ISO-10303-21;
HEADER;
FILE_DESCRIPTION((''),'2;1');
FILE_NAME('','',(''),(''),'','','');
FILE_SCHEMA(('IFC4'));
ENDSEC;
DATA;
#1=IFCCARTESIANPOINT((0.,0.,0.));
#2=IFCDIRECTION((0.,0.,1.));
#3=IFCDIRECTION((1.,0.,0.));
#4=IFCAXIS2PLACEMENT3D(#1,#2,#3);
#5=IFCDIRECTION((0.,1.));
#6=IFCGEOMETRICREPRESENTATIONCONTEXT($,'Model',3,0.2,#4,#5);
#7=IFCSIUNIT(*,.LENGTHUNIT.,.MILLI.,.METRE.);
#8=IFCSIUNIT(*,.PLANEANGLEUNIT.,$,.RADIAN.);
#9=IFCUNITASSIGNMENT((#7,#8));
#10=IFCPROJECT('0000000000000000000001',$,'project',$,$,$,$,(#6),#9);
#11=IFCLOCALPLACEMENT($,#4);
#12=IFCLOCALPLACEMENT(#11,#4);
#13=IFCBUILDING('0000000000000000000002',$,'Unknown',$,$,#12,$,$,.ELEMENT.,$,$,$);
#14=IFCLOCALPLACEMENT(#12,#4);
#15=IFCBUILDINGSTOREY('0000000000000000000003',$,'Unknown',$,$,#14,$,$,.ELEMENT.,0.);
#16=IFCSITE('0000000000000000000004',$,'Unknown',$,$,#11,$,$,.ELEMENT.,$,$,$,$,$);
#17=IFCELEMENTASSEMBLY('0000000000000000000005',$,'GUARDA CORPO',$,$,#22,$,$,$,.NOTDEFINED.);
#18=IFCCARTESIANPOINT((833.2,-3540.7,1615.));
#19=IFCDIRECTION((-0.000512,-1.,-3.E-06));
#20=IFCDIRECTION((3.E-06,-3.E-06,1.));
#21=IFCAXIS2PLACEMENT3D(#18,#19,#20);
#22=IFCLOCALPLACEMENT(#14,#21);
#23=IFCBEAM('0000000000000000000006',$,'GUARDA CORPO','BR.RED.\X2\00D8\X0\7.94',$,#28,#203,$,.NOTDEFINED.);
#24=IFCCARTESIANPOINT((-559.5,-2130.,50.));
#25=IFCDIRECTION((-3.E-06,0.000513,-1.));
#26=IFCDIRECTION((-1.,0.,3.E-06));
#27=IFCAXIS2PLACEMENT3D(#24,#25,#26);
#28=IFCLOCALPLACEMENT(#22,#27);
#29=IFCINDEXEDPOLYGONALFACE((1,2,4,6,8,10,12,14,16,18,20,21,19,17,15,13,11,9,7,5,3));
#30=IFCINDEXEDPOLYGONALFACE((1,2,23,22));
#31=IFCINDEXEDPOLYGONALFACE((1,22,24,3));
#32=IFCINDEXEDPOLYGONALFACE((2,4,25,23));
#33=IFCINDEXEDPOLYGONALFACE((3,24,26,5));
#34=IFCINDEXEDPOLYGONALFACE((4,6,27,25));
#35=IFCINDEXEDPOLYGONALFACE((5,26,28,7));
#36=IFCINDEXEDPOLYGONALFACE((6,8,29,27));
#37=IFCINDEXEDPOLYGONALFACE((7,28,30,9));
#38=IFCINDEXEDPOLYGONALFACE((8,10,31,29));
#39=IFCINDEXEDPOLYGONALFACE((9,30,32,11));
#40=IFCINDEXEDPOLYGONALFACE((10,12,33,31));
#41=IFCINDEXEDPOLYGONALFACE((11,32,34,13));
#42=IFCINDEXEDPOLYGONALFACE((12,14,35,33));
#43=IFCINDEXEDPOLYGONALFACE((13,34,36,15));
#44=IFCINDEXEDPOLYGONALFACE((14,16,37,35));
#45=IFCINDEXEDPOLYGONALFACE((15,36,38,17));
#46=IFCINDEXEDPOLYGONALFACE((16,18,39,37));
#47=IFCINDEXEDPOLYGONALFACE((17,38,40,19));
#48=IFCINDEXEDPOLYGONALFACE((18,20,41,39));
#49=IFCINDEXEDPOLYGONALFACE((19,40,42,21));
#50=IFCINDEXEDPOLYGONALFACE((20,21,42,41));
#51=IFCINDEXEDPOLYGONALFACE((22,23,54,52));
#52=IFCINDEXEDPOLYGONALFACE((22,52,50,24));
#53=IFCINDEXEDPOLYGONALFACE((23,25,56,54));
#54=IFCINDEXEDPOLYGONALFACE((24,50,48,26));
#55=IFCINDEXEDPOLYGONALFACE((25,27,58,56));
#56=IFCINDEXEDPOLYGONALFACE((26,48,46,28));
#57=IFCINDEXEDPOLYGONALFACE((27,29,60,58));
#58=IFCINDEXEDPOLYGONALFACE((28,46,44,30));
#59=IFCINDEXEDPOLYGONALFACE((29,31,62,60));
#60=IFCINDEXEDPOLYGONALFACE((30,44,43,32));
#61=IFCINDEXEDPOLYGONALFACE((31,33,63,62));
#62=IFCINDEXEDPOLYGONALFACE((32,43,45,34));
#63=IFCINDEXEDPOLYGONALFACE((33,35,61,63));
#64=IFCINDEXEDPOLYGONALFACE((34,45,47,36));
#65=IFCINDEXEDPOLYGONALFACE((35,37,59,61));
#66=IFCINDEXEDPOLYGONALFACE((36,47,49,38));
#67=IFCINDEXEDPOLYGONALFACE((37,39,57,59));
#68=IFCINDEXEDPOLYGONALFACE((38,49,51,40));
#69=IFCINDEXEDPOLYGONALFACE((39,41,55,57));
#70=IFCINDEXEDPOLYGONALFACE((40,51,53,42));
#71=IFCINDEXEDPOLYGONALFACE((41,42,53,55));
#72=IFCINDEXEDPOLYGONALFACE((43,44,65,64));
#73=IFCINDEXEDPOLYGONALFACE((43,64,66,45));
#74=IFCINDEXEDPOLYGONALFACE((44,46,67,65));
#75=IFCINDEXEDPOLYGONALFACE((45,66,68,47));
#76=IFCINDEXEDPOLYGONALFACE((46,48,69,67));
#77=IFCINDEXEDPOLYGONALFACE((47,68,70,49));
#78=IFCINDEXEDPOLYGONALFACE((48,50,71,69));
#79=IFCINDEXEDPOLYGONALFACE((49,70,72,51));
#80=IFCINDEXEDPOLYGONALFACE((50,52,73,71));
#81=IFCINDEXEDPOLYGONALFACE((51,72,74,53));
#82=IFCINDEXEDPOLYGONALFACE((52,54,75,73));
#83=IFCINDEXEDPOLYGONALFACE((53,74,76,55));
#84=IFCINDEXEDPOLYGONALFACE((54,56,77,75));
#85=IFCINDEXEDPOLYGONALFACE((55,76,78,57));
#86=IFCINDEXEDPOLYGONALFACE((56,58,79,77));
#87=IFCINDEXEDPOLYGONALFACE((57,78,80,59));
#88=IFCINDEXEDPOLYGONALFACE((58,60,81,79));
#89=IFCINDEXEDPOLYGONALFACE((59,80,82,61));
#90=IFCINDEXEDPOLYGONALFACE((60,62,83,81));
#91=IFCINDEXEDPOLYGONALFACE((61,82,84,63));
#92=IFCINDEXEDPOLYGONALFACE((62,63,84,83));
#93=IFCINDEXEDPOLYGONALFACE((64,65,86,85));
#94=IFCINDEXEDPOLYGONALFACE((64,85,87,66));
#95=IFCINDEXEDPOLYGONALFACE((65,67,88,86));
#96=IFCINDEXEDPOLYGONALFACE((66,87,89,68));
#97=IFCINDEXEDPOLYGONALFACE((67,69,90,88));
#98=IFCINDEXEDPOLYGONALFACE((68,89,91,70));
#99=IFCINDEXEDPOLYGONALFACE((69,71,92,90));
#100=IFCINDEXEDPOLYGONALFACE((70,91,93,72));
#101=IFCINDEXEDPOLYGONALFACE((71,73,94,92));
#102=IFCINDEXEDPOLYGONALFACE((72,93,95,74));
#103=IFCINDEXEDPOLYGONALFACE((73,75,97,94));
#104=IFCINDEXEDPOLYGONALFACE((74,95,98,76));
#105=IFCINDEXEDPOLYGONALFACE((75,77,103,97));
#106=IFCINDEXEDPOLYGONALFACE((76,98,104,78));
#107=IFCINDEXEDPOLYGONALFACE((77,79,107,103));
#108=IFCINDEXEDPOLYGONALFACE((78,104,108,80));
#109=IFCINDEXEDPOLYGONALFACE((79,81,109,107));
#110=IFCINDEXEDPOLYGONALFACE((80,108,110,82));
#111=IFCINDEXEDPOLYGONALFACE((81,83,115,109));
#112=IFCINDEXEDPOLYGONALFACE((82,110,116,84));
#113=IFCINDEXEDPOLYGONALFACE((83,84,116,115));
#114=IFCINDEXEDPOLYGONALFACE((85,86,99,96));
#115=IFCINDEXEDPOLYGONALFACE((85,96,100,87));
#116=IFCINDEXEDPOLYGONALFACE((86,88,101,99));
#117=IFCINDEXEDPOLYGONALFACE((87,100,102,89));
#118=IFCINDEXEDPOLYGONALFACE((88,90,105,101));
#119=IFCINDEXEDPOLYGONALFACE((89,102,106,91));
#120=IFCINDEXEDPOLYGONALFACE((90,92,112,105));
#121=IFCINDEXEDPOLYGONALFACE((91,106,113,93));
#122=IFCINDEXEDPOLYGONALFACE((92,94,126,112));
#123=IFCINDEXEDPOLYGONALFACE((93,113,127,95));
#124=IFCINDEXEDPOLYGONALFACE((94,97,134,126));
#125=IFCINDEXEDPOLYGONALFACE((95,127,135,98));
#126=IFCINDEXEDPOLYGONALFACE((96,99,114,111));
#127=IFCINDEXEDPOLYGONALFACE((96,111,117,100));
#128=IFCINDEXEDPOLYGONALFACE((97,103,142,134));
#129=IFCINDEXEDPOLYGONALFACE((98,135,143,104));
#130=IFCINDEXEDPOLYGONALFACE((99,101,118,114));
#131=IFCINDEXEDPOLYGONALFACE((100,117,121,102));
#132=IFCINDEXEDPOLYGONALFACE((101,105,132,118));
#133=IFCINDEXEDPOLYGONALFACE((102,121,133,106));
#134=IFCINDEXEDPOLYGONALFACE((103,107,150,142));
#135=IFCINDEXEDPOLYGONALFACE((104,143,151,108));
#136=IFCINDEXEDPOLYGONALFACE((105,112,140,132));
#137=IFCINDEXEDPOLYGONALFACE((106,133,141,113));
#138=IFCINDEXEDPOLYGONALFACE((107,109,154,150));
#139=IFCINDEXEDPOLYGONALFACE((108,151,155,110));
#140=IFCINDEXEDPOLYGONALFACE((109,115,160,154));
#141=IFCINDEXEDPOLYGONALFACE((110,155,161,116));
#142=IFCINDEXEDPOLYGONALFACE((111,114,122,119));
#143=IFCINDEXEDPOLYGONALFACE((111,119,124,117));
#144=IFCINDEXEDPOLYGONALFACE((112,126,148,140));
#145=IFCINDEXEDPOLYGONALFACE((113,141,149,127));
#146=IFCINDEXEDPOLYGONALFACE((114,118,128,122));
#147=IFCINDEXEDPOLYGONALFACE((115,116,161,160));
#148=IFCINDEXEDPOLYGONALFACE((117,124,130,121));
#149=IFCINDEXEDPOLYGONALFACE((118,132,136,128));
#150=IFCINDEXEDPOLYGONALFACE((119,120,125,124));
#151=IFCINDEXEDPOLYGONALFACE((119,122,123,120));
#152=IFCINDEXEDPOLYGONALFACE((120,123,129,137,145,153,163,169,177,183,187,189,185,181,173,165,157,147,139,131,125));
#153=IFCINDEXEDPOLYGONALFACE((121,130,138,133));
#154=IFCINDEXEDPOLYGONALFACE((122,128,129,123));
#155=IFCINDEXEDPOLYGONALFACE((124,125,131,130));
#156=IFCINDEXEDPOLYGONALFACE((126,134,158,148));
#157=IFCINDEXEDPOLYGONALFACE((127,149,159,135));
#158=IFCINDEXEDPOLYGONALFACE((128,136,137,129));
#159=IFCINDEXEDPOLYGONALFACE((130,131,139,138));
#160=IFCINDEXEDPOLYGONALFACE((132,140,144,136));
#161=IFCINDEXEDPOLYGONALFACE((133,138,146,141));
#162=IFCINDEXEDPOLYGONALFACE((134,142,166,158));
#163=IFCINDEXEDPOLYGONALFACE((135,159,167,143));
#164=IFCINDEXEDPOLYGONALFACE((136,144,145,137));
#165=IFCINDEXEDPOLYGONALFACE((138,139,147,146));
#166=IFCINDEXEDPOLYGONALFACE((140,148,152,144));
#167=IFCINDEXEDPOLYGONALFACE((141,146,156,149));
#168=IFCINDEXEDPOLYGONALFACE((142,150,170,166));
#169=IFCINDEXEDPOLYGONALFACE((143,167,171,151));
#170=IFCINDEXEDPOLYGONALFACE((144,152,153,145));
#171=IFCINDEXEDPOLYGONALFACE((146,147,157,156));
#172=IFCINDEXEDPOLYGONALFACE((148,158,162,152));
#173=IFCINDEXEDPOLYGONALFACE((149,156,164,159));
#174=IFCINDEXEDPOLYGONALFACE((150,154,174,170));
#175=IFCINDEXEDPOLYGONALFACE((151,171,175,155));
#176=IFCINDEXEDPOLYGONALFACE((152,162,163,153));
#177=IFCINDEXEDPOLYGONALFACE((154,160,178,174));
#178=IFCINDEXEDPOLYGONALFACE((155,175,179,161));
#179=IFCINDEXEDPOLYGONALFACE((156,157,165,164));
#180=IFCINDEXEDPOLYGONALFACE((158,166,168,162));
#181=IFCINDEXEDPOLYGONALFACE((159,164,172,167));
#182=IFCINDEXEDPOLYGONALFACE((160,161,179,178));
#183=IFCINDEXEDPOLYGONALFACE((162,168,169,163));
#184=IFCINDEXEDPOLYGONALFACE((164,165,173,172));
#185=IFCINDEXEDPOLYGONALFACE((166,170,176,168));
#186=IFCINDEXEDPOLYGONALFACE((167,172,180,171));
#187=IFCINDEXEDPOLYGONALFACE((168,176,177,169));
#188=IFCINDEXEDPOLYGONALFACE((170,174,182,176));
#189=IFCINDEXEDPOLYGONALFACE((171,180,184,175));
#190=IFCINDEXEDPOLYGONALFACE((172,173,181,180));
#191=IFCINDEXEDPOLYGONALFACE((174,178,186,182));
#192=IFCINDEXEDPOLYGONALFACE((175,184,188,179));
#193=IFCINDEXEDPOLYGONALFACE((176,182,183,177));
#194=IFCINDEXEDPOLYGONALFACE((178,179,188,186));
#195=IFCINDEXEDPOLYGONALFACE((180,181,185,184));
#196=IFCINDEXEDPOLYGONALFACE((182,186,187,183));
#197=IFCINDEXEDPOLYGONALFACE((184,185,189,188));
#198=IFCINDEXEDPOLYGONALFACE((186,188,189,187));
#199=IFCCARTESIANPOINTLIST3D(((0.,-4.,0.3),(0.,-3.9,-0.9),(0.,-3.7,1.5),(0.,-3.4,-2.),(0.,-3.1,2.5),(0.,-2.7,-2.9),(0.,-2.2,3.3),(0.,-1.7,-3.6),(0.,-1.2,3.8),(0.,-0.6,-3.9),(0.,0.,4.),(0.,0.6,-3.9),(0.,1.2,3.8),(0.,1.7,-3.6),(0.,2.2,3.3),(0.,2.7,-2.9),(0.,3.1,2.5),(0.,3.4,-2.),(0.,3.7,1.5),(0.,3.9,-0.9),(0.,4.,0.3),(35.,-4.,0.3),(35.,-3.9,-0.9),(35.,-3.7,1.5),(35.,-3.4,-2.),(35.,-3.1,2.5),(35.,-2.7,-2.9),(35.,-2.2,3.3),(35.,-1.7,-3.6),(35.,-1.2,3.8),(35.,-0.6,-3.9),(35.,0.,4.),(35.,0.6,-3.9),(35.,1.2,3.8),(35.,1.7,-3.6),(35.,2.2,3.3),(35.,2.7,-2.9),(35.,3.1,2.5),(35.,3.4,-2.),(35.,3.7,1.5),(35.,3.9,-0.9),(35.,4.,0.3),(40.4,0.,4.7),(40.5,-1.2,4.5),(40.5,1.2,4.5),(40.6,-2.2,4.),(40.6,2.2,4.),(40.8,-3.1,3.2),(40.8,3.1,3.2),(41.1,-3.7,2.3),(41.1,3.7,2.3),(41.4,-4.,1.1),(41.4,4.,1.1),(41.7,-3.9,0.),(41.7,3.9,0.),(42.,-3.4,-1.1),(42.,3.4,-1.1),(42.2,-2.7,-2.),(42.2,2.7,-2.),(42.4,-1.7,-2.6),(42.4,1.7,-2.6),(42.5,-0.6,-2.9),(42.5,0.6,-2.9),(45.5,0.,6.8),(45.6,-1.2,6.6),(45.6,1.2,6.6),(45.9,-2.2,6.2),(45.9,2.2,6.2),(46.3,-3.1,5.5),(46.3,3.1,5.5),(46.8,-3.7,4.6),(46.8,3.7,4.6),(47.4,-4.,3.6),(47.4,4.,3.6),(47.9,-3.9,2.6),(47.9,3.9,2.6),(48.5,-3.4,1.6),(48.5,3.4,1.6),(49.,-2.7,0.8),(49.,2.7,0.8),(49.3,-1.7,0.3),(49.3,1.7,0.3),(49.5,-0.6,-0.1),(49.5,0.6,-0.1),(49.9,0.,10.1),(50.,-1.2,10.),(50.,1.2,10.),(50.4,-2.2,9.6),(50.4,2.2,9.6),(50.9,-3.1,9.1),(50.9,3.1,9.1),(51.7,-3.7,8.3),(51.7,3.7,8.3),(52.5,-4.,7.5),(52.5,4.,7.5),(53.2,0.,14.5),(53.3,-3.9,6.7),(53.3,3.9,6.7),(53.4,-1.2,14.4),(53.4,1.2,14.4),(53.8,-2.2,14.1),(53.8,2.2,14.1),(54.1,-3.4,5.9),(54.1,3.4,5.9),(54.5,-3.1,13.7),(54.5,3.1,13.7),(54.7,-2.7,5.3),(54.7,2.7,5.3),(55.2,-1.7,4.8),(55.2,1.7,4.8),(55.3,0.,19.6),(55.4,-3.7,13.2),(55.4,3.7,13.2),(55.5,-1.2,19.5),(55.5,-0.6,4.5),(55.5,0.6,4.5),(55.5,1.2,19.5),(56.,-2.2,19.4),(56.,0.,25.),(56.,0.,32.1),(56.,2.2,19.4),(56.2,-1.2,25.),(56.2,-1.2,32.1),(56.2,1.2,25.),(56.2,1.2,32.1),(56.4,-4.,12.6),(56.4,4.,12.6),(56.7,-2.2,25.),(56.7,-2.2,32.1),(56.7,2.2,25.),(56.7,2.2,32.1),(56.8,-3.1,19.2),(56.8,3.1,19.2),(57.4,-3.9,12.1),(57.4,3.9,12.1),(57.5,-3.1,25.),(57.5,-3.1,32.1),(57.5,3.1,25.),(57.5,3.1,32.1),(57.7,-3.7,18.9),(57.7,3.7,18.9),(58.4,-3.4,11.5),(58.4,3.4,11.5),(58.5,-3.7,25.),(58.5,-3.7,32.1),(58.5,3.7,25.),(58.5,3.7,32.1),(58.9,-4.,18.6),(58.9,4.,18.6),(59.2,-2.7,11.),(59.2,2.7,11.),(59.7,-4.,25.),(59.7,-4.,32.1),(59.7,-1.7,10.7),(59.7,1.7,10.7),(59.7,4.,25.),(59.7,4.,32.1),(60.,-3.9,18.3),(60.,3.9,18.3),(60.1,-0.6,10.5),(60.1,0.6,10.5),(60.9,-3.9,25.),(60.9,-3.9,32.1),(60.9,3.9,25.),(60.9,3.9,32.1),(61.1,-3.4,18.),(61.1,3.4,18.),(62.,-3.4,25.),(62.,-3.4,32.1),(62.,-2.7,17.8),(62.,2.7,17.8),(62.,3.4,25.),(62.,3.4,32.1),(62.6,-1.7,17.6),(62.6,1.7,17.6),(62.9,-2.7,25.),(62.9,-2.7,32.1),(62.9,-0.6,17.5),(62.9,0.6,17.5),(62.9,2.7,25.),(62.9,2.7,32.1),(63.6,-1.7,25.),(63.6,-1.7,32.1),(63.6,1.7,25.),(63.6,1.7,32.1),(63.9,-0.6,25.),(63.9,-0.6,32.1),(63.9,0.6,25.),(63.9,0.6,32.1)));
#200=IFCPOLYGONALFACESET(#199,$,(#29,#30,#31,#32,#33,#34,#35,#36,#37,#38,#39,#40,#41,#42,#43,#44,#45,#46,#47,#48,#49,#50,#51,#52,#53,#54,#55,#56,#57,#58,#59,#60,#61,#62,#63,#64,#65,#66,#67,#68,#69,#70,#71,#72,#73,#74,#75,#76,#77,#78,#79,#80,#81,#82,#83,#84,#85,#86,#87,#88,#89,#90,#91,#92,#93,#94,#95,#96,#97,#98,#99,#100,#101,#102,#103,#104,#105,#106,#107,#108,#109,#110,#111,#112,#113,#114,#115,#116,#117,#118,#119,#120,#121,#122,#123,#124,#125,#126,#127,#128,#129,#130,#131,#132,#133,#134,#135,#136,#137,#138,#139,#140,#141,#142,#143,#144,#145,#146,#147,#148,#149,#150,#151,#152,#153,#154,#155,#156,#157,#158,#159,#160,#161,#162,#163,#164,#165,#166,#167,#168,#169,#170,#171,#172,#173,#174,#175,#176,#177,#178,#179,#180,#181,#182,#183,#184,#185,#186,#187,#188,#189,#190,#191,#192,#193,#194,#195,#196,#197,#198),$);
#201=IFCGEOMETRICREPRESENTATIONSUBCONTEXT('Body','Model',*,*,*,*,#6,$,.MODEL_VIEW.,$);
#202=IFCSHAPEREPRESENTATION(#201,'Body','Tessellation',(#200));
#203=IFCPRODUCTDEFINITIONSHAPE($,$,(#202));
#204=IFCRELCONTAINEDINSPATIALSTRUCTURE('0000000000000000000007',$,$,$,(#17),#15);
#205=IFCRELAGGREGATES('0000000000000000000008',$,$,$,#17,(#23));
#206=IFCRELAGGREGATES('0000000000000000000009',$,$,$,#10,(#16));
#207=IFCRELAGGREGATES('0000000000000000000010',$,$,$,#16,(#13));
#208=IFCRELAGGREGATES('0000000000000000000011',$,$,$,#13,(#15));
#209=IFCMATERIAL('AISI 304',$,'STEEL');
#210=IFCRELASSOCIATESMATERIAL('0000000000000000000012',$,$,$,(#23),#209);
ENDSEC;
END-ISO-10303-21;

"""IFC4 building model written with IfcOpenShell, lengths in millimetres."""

from ifc_helpers import new_model, entity, si_unit, direction, frame, origin_with_axes, place, context, subcontext, project, spatial, material, element, aggregate, save


model = new_model("IFC4")

# Units and contexts
model_context = context("Model", 3, precision=0.2, world=origin_with_axes(), true_north=direction((0.0, 1.0)))
body_context = subcontext(model_context, "Body", "Model", "MODEL_VIEW")
ifc_project = project(units=[si_unit("LENGTHUNIT", "METRE", prefix="MILLI"), si_unit("PLANEANGLEUNIT", "RADIAN")], contexts=[model_context])

# Site, building, storey
site_placement = place(None, origin_with_axes())
site = spatial("IfcSite", under=ifc_project, at=site_placement, Name="Unknown", CompositionType="ELEMENT")
building_placement = place(site_placement, origin_with_axes())
building = spatial("IfcBuilding", under=site, at=building_placement, Name="Unknown", CompositionType="ELEMENT")
storey_placement = place(building_placement, origin_with_axes())
storey = spatial("IfcBuildingStorey", under=building, at=storey_placement, Name="Unknown", CompositionType="ELEMENT", Elevation=0.0)

# Shared definitions
ifc_material_1 = material(Name="AISI 304", Category="STEEL")

# Element assembly, beam
assembly_1_placement = place(storey_placement, frame((833.2, -3540.7, 1615.0), z_axis=(-0.000512, -1.0, -0.000003), x_axis=(0.000003, -0.000003, 1.0)))
assembly_1 = element("IfcElementAssembly", 1, at=assembly_1_placement, inside=storey, Name="GUARDA CORPO", PredefinedType="NOTDEFINED")
beam_1_placement = place(assembly_1_placement, frame((-559.5, -2130.0, 50.0), z_axis=(-0.000003, 0.000513, -1.0), x_axis=(-1.0, 0.0, 0.000003)))
beam_1 = element("IfcBeam", 2, at=beam_1_placement, material=ifc_material_1, Name="GUARDA CORPO", Description="BR.RED.Ø7.94", PredefinedType="NOTDEFINED", context=body_context, shape_type="SolidModel", body=[
    entity("IfcSweptDiskSolid", entity("IfcIndexedPolyCurve", entity("IfcCartesianPointList3D", [[0.0, 0.0, 0.0], [35.0, 0.0, 0.0], [52.7, 0.0, 7.3], [60.0, 0.0, 25.0], [60.0, 0.0, 32.1]]), [entity("IfcLineIndex", [1, 2]), entity("IfcArcIndex", [2, 3, 4]), entity("IfcLineIndex", [4, 5])]), 4.0),
])

aggregate(assembly_1, [beam_1])

save(model, "model.ifc")
